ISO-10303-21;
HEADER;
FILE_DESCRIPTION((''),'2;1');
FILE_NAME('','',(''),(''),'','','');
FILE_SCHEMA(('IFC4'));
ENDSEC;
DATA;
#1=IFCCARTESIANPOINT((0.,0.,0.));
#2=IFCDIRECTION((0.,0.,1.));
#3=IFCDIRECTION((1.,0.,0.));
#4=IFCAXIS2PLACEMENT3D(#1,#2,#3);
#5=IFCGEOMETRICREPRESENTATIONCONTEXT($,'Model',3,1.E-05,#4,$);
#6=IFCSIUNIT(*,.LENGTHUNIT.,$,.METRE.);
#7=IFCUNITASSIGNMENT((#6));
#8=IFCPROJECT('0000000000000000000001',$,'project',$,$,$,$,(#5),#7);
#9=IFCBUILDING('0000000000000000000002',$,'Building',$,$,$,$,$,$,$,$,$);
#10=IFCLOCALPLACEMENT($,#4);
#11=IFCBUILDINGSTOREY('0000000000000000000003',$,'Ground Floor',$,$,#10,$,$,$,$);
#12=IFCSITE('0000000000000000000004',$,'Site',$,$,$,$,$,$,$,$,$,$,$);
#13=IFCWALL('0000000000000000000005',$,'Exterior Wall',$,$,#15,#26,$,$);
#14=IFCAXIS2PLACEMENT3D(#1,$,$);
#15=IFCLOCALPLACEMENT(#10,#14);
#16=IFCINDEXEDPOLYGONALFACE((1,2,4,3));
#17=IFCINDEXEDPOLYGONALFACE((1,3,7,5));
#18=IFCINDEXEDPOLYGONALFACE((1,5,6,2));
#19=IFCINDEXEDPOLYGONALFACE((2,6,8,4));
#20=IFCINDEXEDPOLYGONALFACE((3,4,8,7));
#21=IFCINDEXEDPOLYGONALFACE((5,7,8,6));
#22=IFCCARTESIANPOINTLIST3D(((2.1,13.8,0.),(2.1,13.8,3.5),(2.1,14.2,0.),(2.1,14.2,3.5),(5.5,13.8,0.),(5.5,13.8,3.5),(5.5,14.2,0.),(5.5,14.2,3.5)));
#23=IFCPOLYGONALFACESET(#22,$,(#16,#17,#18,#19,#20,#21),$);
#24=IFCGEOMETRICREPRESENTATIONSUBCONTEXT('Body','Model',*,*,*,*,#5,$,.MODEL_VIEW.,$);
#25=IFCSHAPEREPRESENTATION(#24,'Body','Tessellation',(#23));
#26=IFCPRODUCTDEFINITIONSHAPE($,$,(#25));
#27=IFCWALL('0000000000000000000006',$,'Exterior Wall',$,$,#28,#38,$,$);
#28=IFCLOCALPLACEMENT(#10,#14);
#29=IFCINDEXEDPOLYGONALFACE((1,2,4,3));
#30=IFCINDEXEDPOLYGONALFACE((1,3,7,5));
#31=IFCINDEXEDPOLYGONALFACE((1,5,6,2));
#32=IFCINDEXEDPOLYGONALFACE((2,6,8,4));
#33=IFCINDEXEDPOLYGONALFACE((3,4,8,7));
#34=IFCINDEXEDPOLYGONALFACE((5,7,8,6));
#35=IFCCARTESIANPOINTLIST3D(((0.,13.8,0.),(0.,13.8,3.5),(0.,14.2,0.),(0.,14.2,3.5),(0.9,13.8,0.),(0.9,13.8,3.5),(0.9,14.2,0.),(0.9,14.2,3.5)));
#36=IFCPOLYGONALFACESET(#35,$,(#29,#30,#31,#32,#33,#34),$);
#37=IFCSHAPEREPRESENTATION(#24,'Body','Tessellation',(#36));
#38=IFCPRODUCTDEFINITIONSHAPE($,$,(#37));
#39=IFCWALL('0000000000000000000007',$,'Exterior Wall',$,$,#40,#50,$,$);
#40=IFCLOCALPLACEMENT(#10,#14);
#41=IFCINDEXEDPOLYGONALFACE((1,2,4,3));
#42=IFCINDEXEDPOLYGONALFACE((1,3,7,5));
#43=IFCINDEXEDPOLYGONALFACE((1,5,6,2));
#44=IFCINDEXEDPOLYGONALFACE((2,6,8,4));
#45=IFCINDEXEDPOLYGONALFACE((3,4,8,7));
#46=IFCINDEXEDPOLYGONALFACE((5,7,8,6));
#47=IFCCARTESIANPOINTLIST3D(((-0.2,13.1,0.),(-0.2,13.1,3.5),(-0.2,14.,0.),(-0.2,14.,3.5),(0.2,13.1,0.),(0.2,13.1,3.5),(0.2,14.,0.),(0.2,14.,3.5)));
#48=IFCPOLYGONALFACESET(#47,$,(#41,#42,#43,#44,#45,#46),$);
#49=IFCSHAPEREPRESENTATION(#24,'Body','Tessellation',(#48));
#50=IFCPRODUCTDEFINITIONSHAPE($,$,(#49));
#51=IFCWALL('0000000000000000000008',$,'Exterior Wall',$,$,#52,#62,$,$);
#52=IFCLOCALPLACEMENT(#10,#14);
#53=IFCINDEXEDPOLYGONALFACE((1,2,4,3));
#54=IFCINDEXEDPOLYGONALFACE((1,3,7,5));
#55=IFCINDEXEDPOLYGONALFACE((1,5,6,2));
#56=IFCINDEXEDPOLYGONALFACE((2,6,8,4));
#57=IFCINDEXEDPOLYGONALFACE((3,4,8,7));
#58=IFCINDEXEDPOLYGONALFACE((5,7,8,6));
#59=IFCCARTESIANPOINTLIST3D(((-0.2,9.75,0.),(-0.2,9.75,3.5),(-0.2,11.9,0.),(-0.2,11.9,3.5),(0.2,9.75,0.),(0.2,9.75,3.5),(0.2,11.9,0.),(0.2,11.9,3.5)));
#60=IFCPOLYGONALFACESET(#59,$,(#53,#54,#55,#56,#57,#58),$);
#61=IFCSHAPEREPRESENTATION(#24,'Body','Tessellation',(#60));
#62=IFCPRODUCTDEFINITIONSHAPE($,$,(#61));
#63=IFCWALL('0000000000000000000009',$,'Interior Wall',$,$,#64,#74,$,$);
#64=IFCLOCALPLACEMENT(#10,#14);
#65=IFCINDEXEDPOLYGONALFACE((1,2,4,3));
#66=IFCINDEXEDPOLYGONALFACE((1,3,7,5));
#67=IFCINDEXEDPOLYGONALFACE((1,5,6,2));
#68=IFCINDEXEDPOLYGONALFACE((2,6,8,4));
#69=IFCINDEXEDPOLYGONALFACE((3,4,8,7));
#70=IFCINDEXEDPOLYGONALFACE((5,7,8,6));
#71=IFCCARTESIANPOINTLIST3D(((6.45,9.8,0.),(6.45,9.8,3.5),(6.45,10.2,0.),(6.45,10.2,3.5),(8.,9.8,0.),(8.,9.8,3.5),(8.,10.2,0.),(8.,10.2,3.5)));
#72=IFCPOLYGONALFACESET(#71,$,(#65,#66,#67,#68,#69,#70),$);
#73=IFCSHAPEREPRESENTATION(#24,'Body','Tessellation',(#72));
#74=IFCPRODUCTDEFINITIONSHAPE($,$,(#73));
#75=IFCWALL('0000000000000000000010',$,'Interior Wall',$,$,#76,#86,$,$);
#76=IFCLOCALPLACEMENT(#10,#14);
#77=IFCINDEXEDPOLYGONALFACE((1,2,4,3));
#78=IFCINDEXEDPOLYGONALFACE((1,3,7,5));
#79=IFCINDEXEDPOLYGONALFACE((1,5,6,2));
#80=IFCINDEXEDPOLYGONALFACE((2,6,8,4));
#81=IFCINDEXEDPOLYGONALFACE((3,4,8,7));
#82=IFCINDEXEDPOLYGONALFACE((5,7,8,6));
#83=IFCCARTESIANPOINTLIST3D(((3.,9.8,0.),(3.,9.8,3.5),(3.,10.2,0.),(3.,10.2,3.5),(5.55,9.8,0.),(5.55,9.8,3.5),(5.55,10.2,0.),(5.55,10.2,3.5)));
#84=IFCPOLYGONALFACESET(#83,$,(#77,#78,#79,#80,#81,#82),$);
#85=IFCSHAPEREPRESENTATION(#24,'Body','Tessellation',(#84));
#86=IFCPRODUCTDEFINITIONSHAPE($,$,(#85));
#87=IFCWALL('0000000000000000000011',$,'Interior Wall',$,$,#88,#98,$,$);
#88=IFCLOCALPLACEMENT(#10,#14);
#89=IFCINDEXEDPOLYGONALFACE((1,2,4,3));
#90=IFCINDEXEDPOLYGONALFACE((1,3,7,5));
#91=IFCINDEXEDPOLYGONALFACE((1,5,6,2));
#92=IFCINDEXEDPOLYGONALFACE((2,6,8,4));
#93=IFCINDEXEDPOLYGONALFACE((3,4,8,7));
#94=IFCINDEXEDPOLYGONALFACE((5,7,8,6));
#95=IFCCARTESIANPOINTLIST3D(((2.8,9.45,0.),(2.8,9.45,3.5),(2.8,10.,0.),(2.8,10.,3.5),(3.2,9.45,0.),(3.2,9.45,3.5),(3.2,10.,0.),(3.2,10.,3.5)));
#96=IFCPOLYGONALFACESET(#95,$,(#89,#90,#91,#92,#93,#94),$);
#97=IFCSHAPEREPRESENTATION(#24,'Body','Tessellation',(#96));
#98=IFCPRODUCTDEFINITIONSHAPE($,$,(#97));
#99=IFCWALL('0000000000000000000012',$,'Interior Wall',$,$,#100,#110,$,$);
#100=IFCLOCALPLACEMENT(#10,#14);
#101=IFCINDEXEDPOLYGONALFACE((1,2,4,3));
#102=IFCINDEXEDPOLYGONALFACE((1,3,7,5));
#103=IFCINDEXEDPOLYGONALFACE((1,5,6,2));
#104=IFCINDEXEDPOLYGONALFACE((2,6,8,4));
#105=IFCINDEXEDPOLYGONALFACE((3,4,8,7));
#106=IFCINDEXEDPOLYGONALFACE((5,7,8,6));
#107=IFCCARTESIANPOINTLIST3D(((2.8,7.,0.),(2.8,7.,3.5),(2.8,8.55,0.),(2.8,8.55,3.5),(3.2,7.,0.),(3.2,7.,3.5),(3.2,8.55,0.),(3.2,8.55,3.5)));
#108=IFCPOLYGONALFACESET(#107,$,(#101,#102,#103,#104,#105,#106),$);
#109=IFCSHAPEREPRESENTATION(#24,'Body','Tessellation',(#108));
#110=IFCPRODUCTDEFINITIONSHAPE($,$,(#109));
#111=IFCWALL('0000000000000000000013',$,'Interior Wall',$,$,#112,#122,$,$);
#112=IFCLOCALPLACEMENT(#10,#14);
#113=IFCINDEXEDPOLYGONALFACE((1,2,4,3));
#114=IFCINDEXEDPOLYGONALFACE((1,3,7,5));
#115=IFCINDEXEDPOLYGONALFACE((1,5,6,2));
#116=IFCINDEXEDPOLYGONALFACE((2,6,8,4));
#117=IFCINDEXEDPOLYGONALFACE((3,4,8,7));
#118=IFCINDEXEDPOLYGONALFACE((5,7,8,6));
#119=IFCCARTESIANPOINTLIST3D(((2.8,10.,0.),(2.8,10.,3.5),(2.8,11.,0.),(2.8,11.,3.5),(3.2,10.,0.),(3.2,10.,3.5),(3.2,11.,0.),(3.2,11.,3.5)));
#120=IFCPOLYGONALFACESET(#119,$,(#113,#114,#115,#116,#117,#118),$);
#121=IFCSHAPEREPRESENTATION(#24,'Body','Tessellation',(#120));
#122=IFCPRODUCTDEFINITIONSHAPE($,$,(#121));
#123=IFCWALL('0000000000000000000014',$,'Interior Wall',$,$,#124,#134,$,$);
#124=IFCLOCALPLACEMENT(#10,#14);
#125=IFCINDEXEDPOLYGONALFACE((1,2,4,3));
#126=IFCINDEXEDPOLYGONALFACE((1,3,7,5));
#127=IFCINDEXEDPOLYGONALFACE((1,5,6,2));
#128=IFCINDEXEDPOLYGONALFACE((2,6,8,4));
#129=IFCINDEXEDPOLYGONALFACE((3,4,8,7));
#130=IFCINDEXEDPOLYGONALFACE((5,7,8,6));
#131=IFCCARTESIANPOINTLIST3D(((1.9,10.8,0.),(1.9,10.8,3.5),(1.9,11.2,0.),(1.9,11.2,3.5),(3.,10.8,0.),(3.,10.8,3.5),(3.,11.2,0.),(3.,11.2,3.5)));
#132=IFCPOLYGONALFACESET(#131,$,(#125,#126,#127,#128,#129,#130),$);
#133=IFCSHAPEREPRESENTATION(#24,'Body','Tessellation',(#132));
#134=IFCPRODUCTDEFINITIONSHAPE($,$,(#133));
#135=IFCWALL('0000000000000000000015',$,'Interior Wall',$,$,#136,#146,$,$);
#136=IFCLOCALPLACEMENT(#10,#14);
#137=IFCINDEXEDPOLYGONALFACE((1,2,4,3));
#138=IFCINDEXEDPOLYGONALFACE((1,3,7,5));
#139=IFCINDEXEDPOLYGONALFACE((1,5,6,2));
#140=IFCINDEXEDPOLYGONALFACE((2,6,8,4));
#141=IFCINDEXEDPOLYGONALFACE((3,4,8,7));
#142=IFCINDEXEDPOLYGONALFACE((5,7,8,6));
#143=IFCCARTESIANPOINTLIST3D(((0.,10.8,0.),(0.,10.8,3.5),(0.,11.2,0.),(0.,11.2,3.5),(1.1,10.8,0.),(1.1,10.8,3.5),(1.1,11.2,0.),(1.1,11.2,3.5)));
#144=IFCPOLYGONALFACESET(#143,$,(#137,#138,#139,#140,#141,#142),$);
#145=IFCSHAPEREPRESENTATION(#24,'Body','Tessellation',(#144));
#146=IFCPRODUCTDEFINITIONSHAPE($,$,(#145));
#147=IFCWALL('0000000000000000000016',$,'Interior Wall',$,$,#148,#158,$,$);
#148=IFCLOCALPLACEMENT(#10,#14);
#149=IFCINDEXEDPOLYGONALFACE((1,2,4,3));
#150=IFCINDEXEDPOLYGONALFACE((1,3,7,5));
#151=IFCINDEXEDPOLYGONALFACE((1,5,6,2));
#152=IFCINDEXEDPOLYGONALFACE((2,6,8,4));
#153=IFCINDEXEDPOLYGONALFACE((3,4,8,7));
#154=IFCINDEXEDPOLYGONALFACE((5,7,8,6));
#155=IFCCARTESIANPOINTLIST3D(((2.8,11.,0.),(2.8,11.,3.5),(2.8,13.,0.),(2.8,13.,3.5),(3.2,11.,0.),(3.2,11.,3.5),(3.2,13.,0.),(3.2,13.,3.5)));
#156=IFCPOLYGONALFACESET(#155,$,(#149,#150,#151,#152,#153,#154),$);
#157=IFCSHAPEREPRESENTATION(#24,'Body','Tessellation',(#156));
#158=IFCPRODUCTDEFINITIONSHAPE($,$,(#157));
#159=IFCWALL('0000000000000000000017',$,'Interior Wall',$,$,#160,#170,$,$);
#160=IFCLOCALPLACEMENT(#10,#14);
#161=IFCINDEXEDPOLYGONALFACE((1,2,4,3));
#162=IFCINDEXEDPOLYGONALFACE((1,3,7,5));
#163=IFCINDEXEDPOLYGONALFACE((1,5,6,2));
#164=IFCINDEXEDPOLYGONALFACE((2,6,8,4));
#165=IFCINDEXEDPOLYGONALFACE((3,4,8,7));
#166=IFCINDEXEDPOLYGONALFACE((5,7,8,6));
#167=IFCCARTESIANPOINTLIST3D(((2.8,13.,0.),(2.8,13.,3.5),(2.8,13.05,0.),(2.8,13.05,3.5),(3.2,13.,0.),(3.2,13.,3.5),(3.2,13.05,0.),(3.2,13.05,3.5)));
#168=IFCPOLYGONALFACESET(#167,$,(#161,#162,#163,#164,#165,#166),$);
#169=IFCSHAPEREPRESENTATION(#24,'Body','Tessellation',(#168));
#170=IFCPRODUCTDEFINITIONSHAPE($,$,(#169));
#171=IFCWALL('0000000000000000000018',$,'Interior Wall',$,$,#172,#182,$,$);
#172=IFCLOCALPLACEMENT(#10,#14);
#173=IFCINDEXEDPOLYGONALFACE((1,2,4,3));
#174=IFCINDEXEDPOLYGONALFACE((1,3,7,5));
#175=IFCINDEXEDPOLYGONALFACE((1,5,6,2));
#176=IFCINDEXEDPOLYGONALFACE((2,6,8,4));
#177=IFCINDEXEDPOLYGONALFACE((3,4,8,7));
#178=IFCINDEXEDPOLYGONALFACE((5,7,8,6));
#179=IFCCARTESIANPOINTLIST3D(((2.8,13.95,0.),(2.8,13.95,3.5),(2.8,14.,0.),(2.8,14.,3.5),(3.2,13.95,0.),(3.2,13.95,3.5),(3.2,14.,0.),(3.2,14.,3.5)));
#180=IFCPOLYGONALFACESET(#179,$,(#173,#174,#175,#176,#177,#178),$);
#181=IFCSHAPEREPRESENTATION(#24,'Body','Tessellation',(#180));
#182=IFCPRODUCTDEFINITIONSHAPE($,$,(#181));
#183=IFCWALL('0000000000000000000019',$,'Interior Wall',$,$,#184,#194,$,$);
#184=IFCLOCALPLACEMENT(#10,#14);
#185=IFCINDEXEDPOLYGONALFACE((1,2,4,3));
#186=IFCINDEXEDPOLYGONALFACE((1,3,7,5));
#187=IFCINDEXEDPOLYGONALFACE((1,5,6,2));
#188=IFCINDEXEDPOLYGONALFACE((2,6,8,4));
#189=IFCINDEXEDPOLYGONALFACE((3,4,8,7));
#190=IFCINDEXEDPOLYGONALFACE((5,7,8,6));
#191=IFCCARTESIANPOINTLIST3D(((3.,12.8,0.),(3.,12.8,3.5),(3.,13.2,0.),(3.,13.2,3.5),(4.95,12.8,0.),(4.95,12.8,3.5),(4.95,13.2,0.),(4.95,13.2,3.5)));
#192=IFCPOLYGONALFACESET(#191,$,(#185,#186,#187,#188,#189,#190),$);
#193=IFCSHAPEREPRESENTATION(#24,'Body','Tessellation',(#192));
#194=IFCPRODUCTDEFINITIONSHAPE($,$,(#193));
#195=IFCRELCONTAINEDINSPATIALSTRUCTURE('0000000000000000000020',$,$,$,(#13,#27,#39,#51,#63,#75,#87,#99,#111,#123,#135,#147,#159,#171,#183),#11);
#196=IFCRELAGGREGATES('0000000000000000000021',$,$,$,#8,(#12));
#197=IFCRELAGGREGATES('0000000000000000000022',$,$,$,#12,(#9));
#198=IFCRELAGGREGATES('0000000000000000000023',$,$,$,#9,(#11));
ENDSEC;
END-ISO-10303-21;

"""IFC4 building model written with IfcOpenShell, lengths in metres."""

from ifc_helpers import new_model, si_unit, frame, origin_with_axes, place, context, subcontext, project, spatial, indexed_curve, outline, extrude, element, save


model = new_model("IFC4")

# Units and contexts
model_context = context("Model", 3, precision=1e-05, world=origin_with_axes())
body_context = subcontext(model_context, "Body", "Model", "MODEL_VIEW")
ifc_project = project(units=[si_unit("LENGTHUNIT", "METRE")], contexts=[model_context])

# Site, building, storey
site = spatial("IfcSite", under=ifc_project, Name="Site")
building = spatial("IfcBuilding", under=site, Name="Building")
storey_placement = place(None, origin_with_axes())
storey = spatial("IfcBuildingStorey", under=building, at=storey_placement, Name="Ground Floor")

# Walls
wall_1_placement = place(storey_placement, frame((5.5, 14.0, 0.0), z_axis=(0.0, 0.0, 1.0), x_axis=(-1.0, 0.0, 0.0)))
element("IfcWall", 1, at=wall_1_placement, inside=storey, Name="Exterior Wall", context=body_context, shape_type="SweptSolid", body=[
    extrude(outline(indexed_curve([(0.0, 0.0), (0.0, 0.4), (3.4, 0.4), (3.4, 0.0), (0.0, 0.0)], self_intersect=False)), frame((0.0, -0.2, 0.0), z_axis=(0.0, 0.0, 1.0), x_axis=(1.0, 0.0, 0.0)), (0.0, 0.0, 1.0), 3.5),
])
for number, where, z_axis, x_axis, name in (
    (2, (0.9, 14.0, 0.0), (0.0, 0.0, 1.0), (-1.0, 0.0, 0.0), "Exterior Wall"),
    (3, (0.0, 14.0, 0.0), (0.0, 0.0, 1.0), (0.0, -1.0, 0.0), "Exterior Wall"),
):
    element("IfcWall", number, at=place(storey_placement, frame(where, z_axis=z_axis, x_axis=x_axis)), inside=storey, Name=name, context=body_context, shape_type="SweptSolid", body=[
        extrude(outline(indexed_curve([(0.0, 0.0), (0.0, 0.4), (0.9, 0.4), (0.9, 0.0), (0.0, 0.0)], self_intersect=False)), frame((0.0, -0.2, 0.0), z_axis=(0.0, 0.0, 1.0), x_axis=(1.0, 0.0, 0.0)), (0.0, 0.0, 1.0), 3.5),
    ])
wall_2_placement = place(storey_placement, frame((0.0, 11.9, 0.0), z_axis=(0.0, 0.0, 1.0), x_axis=(0.0, -1.0, 0.0)))
element("IfcWall", 4, at=wall_2_placement, inside=storey, Name="Exterior Wall", context=body_context, shape_type="SweptSolid", body=[
    extrude(outline(indexed_curve([(0.0, 0.0), (0.0, 0.4), (2.15, 0.4), (2.15, 0.0), (0.0, 0.0)], self_intersect=False)), frame((0.0, -0.2, 0.0), z_axis=(0.0, 0.0, 1.0), x_axis=(1.0, 0.0, 0.0)), (0.0, 0.0, 1.0), 3.5),
])
wall_3_placement = place(storey_placement, frame((8.0, 10.0, 0.0), z_axis=(0.0, 0.0, 1.0), x_axis=(-1.0, 0.0, 0.0)))
element("IfcWall", 5, at=wall_3_placement, inside=storey, Name="Interior Wall", context=body_context, shape_type="SweptSolid", body=[
    extrude(outline(indexed_curve([(0.0, 0.0), (0.0, 0.4), (1.55, 0.4), (1.55, 0.0), (0.0, 0.0)], self_intersect=False)), frame((0.0, -0.2, 0.0), z_axis=(0.0, 0.0, 1.0), x_axis=(1.0, 0.0, 0.0)), (0.0, 0.0, 1.0), 3.5),
])
wall_4_placement = place(storey_placement, frame((5.55, 10.0, 0.0), z_axis=(0.0, 0.0, 1.0), x_axis=(-1.0, 0.0, 0.0)))
element("IfcWall", 6, at=wall_4_placement, inside=storey, Name="Interior Wall", context=body_context, shape_type="SweptSolid", body=[
    extrude(outline(indexed_curve([(0.0, 0.0), (0.0, 0.4), (2.55, 0.4), (2.55, 0.0), (0.0, 0.0)], self_intersect=False)), frame((0.0, -0.2, 0.0), z_axis=(0.0, 0.0, 1.0), x_axis=(1.0, 0.0, 0.0)), (0.0, 0.0, 1.0), 3.5),
])
wall_5_placement = place(storey_placement, frame((3.0, 10.0, 0.0), z_axis=(0.0, 0.0, 1.0), x_axis=(0.0, -1.0, 0.0)))
element("IfcWall", 7, at=wall_5_placement, inside=storey, Name="Interior Wall", context=body_context, shape_type="SweptSolid", body=[
    extrude(outline(indexed_curve([(0.0, 0.0), (0.0, 0.4), (0.55, 0.4), (0.55, 0.0), (0.0, 0.0)], self_intersect=False)), frame((0.0, -0.2, 0.0), z_axis=(0.0, 0.0, 1.0), x_axis=(1.0, 0.0, 0.0)), (0.0, 0.0, 1.0), 3.5),
])
wall_6_placement = place(storey_placement, frame((3.0, 8.55, 0.0), z_axis=(0.0, 0.0, 1.0), x_axis=(0.0, -1.0, 0.0)))
element("IfcWall", 8, at=wall_6_placement, inside=storey, Name="Interior Wall", context=body_context, shape_type="SweptSolid", body=[
    extrude(outline(indexed_curve([(0.0, 0.0), (0.0, 0.4), (1.55, 0.4), (1.55, 0.0), (0.0, 0.0)], self_intersect=False)), frame((0.0, -0.2, 0.0), z_axis=(0.0, 0.0, 1.0), x_axis=(1.0, 0.0, 0.0)), (0.0, 0.0, 1.0), 3.5),
])
wall_7_placement = place(storey_placement, frame((3.0, 10.0, 0.0), z_axis=(0.0, 0.0, 1.0), x_axis=(0.0, 1.0, 0.0)))
element("IfcWall", 9, at=wall_7_placement, inside=storey, Name="Interior Wall", context=body_context, shape_type="SweptSolid", body=[
    extrude(outline(indexed_curve([(0.0, 0.0), (0.0, 0.4), (1.0, 0.4), (1.0, 0.0), (0.0, 0.0)], self_intersect=False)), frame((0.0, -0.2, 0.0), z_axis=(0.0, 0.0, 1.0), x_axis=(1.0, 0.0, 0.0)), (0.0, 0.0, 1.0), 3.5),
])
for number, where, z_axis, x_axis, name in (
    (10, (3.0, 11.0, 0.0), (0.0, 0.0, 1.0), (-1.0, 0.0, 0.0), "Interior Wall"),
    (11, (1.1, 11.0, 0.0), (0.0, 0.0, 1.0), (-1.0, 0.0, 0.0), "Interior Wall"),
):
    element("IfcWall", number, at=place(storey_placement, frame(where, z_axis=z_axis, x_axis=x_axis)), inside=storey, Name=name, context=body_context, shape_type="SweptSolid", body=[
        extrude(outline(indexed_curve([(0.0, 0.0), (0.0, 0.4), (1.1, 0.4), (1.1, 0.0), (0.0, 0.0)], self_intersect=False)), frame((0.0, -0.2, 0.0), z_axis=(0.0, 0.0, 1.0), x_axis=(1.0, 0.0, 0.0)), (0.0, 0.0, 1.0), 3.5),
    ])
wall_8_placement = place(storey_placement, frame((3.0, 11.0, 0.0), z_axis=(0.0, 0.0, 1.0), x_axis=(0.0, 1.0, 0.0)))
element("IfcWall", 12, at=wall_8_placement, inside=storey, Name="Interior Wall", context=body_context, shape_type="SweptSolid", body=[
    extrude(outline(indexed_curve([(0.0, 0.0), (0.0, 0.4), (2.0, 0.4), (2.0, 0.0), (0.0, 0.0)], self_intersect=False)), frame((0.0, -0.2, 0.0), z_axis=(0.0, 0.0, 1.0), x_axis=(1.0, 0.0, 0.0)), (0.0, 0.0, 1.0), 3.5),
])
for number, where, z_axis, x_axis, name in (
    (13, (3.0, 13.0, 0.0), (0.0, 0.0, 1.0), (0.0, 1.0, 0.0), "Interior Wall"),
    (14, (3.0, 13.95, 0.0), (0.0, 0.0, 1.0), (0.0, 1.0, 0.0), "Interior Wall"),
):
    element("IfcWall", number, at=place(storey_placement, frame(where, z_axis=z_axis, x_axis=x_axis)), inside=storey, Name=name, context=body_context, shape_type="SweptSolid", body=[
        extrude(outline(indexed_curve([(0.0, 0.0), (0.0, 0.4), (0.05, 0.4), (0.05, 0.0), (0.0, 0.0)], self_intersect=False)), frame((0.0, -0.2, 0.0), z_axis=(0.0, 0.0, 1.0), x_axis=(1.0, 0.0, 0.0)), (0.0, 0.0, 1.0), 3.5),
    ])
wall_9_placement = place(storey_placement, frame((4.95, 13.0, 0.0), z_axis=(0.0, 0.0, 1.0), x_axis=(-1.0, 0.0, 0.0)))
element("IfcWall", 15, at=wall_9_placement, inside=storey, Name="Interior Wall", context=body_context, shape_type="SweptSolid", body=[
    extrude(outline(indexed_curve([(0.0, 0.0), (0.0, 0.4), (1.95, 0.4), (1.95, 0.0), (0.0, 0.0)], self_intersect=False)), frame((0.0, -0.2, 0.0), z_axis=(0.0, 0.0, 1.0), x_axis=(1.0, 0.0, 0.0)), (0.0, 0.0, 1.0), 3.5),
])

save(model, "model.ifc")
